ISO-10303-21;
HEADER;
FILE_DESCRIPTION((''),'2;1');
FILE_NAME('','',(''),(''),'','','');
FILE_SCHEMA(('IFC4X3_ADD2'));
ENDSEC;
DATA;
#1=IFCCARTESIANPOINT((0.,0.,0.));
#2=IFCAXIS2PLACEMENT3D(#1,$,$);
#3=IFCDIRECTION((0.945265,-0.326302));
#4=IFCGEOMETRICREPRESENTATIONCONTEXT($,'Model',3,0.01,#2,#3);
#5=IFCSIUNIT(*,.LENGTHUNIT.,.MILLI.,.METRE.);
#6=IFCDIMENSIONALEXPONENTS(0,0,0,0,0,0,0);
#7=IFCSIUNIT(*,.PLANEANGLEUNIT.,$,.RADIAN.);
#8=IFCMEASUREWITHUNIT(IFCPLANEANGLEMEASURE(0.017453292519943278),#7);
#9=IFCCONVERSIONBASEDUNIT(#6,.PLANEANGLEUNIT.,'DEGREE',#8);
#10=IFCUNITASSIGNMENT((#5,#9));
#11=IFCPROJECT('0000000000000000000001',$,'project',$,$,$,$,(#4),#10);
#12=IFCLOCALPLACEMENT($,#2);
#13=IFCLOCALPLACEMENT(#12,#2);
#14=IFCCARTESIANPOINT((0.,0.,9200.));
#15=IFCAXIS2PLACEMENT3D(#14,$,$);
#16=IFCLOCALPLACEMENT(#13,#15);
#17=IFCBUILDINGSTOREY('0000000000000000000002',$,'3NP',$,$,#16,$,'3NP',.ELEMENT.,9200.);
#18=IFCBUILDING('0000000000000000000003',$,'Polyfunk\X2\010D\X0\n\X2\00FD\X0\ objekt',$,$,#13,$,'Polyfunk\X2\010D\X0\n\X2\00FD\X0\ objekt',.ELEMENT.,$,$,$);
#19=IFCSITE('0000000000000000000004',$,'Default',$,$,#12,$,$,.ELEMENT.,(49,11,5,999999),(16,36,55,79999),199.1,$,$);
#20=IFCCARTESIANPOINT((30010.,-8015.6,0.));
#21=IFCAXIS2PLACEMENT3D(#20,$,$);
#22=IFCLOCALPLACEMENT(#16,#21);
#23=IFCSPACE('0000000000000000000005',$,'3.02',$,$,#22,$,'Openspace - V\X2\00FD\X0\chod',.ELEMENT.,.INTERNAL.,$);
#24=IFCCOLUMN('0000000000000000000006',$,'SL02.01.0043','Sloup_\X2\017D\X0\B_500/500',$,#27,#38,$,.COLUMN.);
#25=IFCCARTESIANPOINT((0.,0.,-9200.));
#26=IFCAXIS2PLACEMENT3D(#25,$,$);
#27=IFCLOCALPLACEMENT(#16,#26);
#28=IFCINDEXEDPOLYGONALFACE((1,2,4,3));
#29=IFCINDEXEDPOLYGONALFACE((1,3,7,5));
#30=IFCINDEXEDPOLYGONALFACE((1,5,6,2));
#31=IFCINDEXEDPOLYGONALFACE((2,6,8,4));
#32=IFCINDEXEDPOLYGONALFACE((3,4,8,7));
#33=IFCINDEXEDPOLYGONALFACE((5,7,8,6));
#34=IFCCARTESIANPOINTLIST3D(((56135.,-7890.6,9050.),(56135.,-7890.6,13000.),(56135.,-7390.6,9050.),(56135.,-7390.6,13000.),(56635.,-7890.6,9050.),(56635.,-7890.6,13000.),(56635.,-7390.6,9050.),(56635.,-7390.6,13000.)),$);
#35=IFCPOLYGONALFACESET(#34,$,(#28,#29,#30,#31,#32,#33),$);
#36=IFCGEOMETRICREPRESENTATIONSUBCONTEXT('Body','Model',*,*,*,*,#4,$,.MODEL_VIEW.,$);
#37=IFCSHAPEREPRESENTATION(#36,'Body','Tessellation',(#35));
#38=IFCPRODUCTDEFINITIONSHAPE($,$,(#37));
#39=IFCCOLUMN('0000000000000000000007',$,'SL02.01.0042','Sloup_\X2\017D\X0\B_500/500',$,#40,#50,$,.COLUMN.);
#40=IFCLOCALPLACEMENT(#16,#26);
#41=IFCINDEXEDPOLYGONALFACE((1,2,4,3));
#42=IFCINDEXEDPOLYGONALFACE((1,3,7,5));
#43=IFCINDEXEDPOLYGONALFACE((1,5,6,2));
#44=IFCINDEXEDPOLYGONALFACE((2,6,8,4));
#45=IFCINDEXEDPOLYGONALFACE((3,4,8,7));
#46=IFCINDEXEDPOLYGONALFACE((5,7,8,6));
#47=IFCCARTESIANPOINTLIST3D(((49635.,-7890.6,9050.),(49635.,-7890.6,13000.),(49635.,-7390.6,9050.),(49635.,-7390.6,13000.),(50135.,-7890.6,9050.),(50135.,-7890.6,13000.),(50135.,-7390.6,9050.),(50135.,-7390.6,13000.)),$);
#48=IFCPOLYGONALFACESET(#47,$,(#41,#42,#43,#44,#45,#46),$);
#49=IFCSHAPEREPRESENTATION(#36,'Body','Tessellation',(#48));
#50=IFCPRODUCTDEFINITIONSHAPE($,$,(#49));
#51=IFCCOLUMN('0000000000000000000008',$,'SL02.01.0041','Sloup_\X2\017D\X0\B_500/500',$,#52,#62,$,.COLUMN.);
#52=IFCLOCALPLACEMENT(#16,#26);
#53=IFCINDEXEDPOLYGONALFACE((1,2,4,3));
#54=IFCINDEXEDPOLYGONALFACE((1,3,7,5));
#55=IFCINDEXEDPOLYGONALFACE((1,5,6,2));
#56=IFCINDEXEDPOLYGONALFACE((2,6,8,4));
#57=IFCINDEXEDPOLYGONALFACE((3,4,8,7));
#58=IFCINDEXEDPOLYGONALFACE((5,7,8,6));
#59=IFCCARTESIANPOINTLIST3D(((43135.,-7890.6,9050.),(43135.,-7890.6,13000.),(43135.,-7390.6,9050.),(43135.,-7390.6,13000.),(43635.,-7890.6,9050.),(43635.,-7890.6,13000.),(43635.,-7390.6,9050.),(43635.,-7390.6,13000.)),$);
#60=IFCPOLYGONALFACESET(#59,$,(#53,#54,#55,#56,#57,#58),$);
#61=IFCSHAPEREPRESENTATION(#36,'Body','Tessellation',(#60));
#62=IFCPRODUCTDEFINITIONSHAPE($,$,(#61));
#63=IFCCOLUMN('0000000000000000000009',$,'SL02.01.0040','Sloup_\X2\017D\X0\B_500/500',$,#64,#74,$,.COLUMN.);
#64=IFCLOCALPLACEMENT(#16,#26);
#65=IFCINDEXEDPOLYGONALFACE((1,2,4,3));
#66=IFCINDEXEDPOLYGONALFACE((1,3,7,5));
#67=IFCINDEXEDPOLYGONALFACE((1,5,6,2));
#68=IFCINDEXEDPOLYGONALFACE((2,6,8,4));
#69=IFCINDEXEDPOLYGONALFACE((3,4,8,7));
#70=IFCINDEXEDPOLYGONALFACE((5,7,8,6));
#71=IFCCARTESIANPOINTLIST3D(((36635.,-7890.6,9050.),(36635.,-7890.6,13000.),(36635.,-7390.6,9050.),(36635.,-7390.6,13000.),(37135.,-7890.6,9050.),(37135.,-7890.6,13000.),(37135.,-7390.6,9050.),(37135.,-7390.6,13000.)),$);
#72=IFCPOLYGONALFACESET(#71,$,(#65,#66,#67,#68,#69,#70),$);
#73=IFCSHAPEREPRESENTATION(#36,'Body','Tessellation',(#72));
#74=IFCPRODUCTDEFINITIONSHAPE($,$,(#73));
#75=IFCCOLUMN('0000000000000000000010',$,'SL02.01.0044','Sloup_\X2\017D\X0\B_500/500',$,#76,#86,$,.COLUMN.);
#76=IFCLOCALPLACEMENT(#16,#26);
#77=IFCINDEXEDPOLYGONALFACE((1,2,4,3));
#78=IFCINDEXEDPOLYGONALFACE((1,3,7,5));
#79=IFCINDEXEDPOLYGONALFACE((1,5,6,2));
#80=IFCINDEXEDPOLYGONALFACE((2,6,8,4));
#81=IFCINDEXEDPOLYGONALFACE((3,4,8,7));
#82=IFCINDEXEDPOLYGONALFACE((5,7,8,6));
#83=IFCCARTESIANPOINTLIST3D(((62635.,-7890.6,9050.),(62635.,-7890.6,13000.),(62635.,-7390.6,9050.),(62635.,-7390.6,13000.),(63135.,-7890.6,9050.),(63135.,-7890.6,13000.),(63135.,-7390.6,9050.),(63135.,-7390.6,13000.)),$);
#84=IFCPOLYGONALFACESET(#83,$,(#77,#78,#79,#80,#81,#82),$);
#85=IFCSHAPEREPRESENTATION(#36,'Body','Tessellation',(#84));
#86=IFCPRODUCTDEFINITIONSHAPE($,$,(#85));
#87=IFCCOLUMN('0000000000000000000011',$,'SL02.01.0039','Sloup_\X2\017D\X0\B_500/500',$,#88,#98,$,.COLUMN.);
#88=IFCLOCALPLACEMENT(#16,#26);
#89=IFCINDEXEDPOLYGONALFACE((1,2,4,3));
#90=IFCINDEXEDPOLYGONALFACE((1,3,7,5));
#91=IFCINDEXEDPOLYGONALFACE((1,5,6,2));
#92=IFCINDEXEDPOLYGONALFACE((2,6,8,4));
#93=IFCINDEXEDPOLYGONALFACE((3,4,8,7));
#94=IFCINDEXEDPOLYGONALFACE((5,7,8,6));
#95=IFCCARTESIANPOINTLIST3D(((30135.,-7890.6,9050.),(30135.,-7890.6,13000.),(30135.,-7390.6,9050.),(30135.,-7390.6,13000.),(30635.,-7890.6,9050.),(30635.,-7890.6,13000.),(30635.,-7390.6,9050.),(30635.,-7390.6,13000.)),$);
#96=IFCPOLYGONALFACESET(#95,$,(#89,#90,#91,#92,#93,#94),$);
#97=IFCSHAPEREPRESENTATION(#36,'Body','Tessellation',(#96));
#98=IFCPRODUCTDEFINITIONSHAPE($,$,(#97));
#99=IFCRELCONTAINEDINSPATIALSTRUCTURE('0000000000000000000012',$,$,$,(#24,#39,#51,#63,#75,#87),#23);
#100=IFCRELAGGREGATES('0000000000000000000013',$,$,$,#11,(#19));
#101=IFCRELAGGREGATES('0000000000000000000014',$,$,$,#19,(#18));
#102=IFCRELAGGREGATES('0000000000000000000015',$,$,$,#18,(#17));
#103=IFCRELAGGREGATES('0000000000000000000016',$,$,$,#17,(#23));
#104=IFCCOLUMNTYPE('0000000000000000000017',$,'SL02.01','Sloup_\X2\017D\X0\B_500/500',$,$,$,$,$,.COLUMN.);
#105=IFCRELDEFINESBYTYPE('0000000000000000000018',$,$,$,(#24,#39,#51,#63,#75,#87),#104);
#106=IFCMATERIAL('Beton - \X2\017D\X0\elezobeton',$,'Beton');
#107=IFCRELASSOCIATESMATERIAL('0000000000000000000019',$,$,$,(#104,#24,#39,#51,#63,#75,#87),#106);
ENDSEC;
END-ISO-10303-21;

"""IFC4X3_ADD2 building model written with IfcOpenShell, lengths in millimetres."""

from ifc_helpers import new_model, entity, si_unit, converted_unit, direction, frame, frame_2d, origin, origin_2d_with_axis, place, context, subcontext, project, spatial, rectangle, extrude, source, transform, mapped, material, material_profile, profile_set, profile_usage, type_object, element, save


model = new_model("IFC4X3_ADD2")

# Units and contexts
model_context = context("Model", 3, precision=0.01, world=origin(), true_north=direction((0.945265, -0.326302)))
body_context = subcontext(model_context, "Body", "Model", "MODEL_VIEW")
ifc_project = project(units=[si_unit("LENGTHUNIT", "METRE", prefix="MILLI"), converted_unit("PLANEANGLEUNIT", "DEGREE", entity("IfcPlaneAngleMeasure", 0.017453292519943278), si_unit("PLANEANGLEUNIT", "RADIAN"), dimensions=[0, 0, 0, 0, 0, 0, 0])], contexts=[model_context])

# Site, building, storey
site_placement = place(None, origin())
site = spatial("IfcSite", under=ifc_project, at=site_placement, Name="Default", CompositionType="ELEMENT", RefLatitude=(49, 11, 5, 999999), RefLongitude=(16, 36, 55, 79999), RefElevation=199.1)
building_placement = place(site_placement, origin())
building = spatial("IfcBuilding", under=site, at=building_placement, Name="Polyfunkčný objekt", LongName="Polyfunkčný objekt", CompositionType="ELEMENT")
storey_placement = place(building_placement, frame((0.0, 0.0, 9200.0)))
storey = spatial("IfcBuildingStorey", under=building, at=storey_placement, Name="3NP", LongName="3NP", CompositionType="ELEMENT", Elevation=9200.0)

# Shared definitions
ifc_material_1 = material(Name="Beton - Železobeton", Category="Beton")
ifc_material_profile_1 = material_profile(ifc_material_1, rectangle(XDim=500.0, YDim=500.0, at=frame_2d((0.0, 0.0), x_axis=(1.0, 0.0))), Name="Sloup_ŽB_500/500")
ifc_profile_set_1 = profile_set([ifc_material_profile_1], Name="Sloup_ŽB_500/500")
ifc_profile_usage_1 = profile_usage(ifc_profile_set_1)
column_type_1 = type_object("IfcColumnType", Name="SL02.01", Description="Sloup_ŽB_500/500", PredefinedType="COLUMN", material=ifc_profile_set_1)

# Shared definitions
space_1_placement = place(storey_placement, frame((30010.0, -8015.6, 0.0)))
space_1 = spatial("IfcSpace", under=storey, at=space_1_placement, Name="3.02", LongName="Openspace - Východ", CompositionType="ELEMENT", PredefinedType="INTERNAL")

# Columns
shared_shape_1 = source(origin(), body_context, "Body", "SweptSolid", [
    extrude(rectangle(XDim=500.0, YDim=500.0, at=origin_2d_with_axis()), frame((56385.0, -7640.6, 9050.0)), (0.0, 0.0, 1.0), 3950.0),
])
column_1_placement = place(storey_placement, frame((0.0, 0.0, -9200.0)))
element("IfcColumn", 1, at=column_1_placement, inside=space_1, type_object=column_type_1, material=ifc_profile_usage_1, Name="SL02.01.0043", Description="Sloup_ŽB_500/500", PredefinedType="COLUMN", context=body_context, shape_type="MappedRepresentation", body=[
    mapped(shared_shape_1, transform((0.0, 0.0, 0.0), scale=1.0)),
])
shared_shape_2 = source(origin(), body_context, "Body", "SweptSolid", [
    extrude(rectangle(XDim=500.0, YDim=500.0, at=frame_2d((0.0, 0.0), x_axis=(1.0, 0.0))), frame((49885.0, -7640.6, 9050.0)), (0.0, 0.0, 1.0), 3950.0),
])
column_2_placement = place(storey_placement, frame((0.0, 0.0, -9200.0)))
element("IfcColumn", 2, at=column_2_placement, inside=space_1, type_object=column_type_1, material=ifc_profile_usage_1, Name="SL02.01.0042", Description="Sloup_ŽB_500/500", PredefinedType="COLUMN", context=body_context, shape_type="MappedRepresentation", body=[
    mapped(shared_shape_2, transform((0.0, 0.0, 0.0), scale=1.0)),
])
shared_shape_3 = source(origin(), body_context, "Body", "SweptSolid", [
    extrude(rectangle(XDim=500.0, YDim=500.0, at=origin_2d_with_axis()), frame((43385.0, -7640.6, 9050.0)), (0.0, 0.0, 1.0), 3950.0),
])
column_3_placement = place(storey_placement, frame((0.0, 0.0, -9200.0)))
element("IfcColumn", 3, at=column_3_placement, inside=space_1, type_object=column_type_1, material=ifc_profile_usage_1, Name="SL02.01.0041", Description="Sloup_ŽB_500/500", PredefinedType="COLUMN", context=body_context, shape_type="MappedRepresentation", body=[
    mapped(shared_shape_3, transform((0.0, 0.0, 0.0), scale=1.0)),
])
shared_shape_4 = source(origin(), body_context, "Body", "SweptSolid", [
    extrude(rectangle(XDim=500.0, YDim=500.0, at=origin_2d_with_axis()), frame((36885.0, -7640.6, 9050.0)), (0.0, 0.0, 1.0), 3950.0),
])
column_4_placement = place(storey_placement, frame((0.0, 0.0, -9200.0)))
element("IfcColumn", 4, at=column_4_placement, inside=space_1, type_object=column_type_1, material=ifc_profile_usage_1, Name="SL02.01.0040", Description="Sloup_ŽB_500/500", PredefinedType="COLUMN", context=body_context, shape_type="MappedRepresentation", body=[
    mapped(shared_shape_4, transform((0.0, 0.0, 0.0), scale=1.0)),
])
shared_shape_5 = source(origin(), body_context, "Body", "SweptSolid", [
    extrude(rectangle(XDim=500.0, YDim=500.0, at=frame_2d((0.0, 0.0), x_axis=(1.0, 0.0))), frame((62885.0, -7640.6, 9050.0), z_axis=(0.0, 0.0, 1.0), x_axis=(-1.0, 0.0, 0.0)), (0.0, 0.0, 1.0), 3950.0),
])
column_5_placement = place(storey_placement, frame((0.0, 0.0, -9200.0)))
element("IfcColumn", 5, at=column_5_placement, inside=space_1, type_object=column_type_1, material=ifc_profile_usage_1, Name="SL02.01.0044", Description="Sloup_ŽB_500/500", PredefinedType="COLUMN", context=body_context, shape_type="MappedRepresentation", body=[
    mapped(shared_shape_5, transform((0.0, 0.0, 0.0), scale=1.0)),
])
shared_shape_6 = source(origin(), body_context, "Body", "SweptSolid", [
    extrude(rectangle(XDim=500.0, YDim=500.0, at=frame_2d((0.0, 0.0), x_axis=(1.0, 0.0))), frame((30385.0, -7640.6, 9050.0), z_axis=(0.0, 0.0, 1.0), x_axis=(-1.0, 0.0, 0.0)), (0.0, 0.0, 1.0), 3950.0),
])
column_6_placement = place(storey_placement, frame((0.0, 0.0, -9200.0)))
element("IfcColumn", 6, at=column_6_placement, inside=space_1, type_object=column_type_1, material=ifc_profile_usage_1, Name="SL02.01.0039", Description="Sloup_ŽB_500/500", PredefinedType="COLUMN", context=body_context, shape_type="MappedRepresentation", body=[
    mapped(shared_shape_6, transform((0.0, 0.0, 0.0), scale=1.0)),
])

save(model, "model.ifc")
